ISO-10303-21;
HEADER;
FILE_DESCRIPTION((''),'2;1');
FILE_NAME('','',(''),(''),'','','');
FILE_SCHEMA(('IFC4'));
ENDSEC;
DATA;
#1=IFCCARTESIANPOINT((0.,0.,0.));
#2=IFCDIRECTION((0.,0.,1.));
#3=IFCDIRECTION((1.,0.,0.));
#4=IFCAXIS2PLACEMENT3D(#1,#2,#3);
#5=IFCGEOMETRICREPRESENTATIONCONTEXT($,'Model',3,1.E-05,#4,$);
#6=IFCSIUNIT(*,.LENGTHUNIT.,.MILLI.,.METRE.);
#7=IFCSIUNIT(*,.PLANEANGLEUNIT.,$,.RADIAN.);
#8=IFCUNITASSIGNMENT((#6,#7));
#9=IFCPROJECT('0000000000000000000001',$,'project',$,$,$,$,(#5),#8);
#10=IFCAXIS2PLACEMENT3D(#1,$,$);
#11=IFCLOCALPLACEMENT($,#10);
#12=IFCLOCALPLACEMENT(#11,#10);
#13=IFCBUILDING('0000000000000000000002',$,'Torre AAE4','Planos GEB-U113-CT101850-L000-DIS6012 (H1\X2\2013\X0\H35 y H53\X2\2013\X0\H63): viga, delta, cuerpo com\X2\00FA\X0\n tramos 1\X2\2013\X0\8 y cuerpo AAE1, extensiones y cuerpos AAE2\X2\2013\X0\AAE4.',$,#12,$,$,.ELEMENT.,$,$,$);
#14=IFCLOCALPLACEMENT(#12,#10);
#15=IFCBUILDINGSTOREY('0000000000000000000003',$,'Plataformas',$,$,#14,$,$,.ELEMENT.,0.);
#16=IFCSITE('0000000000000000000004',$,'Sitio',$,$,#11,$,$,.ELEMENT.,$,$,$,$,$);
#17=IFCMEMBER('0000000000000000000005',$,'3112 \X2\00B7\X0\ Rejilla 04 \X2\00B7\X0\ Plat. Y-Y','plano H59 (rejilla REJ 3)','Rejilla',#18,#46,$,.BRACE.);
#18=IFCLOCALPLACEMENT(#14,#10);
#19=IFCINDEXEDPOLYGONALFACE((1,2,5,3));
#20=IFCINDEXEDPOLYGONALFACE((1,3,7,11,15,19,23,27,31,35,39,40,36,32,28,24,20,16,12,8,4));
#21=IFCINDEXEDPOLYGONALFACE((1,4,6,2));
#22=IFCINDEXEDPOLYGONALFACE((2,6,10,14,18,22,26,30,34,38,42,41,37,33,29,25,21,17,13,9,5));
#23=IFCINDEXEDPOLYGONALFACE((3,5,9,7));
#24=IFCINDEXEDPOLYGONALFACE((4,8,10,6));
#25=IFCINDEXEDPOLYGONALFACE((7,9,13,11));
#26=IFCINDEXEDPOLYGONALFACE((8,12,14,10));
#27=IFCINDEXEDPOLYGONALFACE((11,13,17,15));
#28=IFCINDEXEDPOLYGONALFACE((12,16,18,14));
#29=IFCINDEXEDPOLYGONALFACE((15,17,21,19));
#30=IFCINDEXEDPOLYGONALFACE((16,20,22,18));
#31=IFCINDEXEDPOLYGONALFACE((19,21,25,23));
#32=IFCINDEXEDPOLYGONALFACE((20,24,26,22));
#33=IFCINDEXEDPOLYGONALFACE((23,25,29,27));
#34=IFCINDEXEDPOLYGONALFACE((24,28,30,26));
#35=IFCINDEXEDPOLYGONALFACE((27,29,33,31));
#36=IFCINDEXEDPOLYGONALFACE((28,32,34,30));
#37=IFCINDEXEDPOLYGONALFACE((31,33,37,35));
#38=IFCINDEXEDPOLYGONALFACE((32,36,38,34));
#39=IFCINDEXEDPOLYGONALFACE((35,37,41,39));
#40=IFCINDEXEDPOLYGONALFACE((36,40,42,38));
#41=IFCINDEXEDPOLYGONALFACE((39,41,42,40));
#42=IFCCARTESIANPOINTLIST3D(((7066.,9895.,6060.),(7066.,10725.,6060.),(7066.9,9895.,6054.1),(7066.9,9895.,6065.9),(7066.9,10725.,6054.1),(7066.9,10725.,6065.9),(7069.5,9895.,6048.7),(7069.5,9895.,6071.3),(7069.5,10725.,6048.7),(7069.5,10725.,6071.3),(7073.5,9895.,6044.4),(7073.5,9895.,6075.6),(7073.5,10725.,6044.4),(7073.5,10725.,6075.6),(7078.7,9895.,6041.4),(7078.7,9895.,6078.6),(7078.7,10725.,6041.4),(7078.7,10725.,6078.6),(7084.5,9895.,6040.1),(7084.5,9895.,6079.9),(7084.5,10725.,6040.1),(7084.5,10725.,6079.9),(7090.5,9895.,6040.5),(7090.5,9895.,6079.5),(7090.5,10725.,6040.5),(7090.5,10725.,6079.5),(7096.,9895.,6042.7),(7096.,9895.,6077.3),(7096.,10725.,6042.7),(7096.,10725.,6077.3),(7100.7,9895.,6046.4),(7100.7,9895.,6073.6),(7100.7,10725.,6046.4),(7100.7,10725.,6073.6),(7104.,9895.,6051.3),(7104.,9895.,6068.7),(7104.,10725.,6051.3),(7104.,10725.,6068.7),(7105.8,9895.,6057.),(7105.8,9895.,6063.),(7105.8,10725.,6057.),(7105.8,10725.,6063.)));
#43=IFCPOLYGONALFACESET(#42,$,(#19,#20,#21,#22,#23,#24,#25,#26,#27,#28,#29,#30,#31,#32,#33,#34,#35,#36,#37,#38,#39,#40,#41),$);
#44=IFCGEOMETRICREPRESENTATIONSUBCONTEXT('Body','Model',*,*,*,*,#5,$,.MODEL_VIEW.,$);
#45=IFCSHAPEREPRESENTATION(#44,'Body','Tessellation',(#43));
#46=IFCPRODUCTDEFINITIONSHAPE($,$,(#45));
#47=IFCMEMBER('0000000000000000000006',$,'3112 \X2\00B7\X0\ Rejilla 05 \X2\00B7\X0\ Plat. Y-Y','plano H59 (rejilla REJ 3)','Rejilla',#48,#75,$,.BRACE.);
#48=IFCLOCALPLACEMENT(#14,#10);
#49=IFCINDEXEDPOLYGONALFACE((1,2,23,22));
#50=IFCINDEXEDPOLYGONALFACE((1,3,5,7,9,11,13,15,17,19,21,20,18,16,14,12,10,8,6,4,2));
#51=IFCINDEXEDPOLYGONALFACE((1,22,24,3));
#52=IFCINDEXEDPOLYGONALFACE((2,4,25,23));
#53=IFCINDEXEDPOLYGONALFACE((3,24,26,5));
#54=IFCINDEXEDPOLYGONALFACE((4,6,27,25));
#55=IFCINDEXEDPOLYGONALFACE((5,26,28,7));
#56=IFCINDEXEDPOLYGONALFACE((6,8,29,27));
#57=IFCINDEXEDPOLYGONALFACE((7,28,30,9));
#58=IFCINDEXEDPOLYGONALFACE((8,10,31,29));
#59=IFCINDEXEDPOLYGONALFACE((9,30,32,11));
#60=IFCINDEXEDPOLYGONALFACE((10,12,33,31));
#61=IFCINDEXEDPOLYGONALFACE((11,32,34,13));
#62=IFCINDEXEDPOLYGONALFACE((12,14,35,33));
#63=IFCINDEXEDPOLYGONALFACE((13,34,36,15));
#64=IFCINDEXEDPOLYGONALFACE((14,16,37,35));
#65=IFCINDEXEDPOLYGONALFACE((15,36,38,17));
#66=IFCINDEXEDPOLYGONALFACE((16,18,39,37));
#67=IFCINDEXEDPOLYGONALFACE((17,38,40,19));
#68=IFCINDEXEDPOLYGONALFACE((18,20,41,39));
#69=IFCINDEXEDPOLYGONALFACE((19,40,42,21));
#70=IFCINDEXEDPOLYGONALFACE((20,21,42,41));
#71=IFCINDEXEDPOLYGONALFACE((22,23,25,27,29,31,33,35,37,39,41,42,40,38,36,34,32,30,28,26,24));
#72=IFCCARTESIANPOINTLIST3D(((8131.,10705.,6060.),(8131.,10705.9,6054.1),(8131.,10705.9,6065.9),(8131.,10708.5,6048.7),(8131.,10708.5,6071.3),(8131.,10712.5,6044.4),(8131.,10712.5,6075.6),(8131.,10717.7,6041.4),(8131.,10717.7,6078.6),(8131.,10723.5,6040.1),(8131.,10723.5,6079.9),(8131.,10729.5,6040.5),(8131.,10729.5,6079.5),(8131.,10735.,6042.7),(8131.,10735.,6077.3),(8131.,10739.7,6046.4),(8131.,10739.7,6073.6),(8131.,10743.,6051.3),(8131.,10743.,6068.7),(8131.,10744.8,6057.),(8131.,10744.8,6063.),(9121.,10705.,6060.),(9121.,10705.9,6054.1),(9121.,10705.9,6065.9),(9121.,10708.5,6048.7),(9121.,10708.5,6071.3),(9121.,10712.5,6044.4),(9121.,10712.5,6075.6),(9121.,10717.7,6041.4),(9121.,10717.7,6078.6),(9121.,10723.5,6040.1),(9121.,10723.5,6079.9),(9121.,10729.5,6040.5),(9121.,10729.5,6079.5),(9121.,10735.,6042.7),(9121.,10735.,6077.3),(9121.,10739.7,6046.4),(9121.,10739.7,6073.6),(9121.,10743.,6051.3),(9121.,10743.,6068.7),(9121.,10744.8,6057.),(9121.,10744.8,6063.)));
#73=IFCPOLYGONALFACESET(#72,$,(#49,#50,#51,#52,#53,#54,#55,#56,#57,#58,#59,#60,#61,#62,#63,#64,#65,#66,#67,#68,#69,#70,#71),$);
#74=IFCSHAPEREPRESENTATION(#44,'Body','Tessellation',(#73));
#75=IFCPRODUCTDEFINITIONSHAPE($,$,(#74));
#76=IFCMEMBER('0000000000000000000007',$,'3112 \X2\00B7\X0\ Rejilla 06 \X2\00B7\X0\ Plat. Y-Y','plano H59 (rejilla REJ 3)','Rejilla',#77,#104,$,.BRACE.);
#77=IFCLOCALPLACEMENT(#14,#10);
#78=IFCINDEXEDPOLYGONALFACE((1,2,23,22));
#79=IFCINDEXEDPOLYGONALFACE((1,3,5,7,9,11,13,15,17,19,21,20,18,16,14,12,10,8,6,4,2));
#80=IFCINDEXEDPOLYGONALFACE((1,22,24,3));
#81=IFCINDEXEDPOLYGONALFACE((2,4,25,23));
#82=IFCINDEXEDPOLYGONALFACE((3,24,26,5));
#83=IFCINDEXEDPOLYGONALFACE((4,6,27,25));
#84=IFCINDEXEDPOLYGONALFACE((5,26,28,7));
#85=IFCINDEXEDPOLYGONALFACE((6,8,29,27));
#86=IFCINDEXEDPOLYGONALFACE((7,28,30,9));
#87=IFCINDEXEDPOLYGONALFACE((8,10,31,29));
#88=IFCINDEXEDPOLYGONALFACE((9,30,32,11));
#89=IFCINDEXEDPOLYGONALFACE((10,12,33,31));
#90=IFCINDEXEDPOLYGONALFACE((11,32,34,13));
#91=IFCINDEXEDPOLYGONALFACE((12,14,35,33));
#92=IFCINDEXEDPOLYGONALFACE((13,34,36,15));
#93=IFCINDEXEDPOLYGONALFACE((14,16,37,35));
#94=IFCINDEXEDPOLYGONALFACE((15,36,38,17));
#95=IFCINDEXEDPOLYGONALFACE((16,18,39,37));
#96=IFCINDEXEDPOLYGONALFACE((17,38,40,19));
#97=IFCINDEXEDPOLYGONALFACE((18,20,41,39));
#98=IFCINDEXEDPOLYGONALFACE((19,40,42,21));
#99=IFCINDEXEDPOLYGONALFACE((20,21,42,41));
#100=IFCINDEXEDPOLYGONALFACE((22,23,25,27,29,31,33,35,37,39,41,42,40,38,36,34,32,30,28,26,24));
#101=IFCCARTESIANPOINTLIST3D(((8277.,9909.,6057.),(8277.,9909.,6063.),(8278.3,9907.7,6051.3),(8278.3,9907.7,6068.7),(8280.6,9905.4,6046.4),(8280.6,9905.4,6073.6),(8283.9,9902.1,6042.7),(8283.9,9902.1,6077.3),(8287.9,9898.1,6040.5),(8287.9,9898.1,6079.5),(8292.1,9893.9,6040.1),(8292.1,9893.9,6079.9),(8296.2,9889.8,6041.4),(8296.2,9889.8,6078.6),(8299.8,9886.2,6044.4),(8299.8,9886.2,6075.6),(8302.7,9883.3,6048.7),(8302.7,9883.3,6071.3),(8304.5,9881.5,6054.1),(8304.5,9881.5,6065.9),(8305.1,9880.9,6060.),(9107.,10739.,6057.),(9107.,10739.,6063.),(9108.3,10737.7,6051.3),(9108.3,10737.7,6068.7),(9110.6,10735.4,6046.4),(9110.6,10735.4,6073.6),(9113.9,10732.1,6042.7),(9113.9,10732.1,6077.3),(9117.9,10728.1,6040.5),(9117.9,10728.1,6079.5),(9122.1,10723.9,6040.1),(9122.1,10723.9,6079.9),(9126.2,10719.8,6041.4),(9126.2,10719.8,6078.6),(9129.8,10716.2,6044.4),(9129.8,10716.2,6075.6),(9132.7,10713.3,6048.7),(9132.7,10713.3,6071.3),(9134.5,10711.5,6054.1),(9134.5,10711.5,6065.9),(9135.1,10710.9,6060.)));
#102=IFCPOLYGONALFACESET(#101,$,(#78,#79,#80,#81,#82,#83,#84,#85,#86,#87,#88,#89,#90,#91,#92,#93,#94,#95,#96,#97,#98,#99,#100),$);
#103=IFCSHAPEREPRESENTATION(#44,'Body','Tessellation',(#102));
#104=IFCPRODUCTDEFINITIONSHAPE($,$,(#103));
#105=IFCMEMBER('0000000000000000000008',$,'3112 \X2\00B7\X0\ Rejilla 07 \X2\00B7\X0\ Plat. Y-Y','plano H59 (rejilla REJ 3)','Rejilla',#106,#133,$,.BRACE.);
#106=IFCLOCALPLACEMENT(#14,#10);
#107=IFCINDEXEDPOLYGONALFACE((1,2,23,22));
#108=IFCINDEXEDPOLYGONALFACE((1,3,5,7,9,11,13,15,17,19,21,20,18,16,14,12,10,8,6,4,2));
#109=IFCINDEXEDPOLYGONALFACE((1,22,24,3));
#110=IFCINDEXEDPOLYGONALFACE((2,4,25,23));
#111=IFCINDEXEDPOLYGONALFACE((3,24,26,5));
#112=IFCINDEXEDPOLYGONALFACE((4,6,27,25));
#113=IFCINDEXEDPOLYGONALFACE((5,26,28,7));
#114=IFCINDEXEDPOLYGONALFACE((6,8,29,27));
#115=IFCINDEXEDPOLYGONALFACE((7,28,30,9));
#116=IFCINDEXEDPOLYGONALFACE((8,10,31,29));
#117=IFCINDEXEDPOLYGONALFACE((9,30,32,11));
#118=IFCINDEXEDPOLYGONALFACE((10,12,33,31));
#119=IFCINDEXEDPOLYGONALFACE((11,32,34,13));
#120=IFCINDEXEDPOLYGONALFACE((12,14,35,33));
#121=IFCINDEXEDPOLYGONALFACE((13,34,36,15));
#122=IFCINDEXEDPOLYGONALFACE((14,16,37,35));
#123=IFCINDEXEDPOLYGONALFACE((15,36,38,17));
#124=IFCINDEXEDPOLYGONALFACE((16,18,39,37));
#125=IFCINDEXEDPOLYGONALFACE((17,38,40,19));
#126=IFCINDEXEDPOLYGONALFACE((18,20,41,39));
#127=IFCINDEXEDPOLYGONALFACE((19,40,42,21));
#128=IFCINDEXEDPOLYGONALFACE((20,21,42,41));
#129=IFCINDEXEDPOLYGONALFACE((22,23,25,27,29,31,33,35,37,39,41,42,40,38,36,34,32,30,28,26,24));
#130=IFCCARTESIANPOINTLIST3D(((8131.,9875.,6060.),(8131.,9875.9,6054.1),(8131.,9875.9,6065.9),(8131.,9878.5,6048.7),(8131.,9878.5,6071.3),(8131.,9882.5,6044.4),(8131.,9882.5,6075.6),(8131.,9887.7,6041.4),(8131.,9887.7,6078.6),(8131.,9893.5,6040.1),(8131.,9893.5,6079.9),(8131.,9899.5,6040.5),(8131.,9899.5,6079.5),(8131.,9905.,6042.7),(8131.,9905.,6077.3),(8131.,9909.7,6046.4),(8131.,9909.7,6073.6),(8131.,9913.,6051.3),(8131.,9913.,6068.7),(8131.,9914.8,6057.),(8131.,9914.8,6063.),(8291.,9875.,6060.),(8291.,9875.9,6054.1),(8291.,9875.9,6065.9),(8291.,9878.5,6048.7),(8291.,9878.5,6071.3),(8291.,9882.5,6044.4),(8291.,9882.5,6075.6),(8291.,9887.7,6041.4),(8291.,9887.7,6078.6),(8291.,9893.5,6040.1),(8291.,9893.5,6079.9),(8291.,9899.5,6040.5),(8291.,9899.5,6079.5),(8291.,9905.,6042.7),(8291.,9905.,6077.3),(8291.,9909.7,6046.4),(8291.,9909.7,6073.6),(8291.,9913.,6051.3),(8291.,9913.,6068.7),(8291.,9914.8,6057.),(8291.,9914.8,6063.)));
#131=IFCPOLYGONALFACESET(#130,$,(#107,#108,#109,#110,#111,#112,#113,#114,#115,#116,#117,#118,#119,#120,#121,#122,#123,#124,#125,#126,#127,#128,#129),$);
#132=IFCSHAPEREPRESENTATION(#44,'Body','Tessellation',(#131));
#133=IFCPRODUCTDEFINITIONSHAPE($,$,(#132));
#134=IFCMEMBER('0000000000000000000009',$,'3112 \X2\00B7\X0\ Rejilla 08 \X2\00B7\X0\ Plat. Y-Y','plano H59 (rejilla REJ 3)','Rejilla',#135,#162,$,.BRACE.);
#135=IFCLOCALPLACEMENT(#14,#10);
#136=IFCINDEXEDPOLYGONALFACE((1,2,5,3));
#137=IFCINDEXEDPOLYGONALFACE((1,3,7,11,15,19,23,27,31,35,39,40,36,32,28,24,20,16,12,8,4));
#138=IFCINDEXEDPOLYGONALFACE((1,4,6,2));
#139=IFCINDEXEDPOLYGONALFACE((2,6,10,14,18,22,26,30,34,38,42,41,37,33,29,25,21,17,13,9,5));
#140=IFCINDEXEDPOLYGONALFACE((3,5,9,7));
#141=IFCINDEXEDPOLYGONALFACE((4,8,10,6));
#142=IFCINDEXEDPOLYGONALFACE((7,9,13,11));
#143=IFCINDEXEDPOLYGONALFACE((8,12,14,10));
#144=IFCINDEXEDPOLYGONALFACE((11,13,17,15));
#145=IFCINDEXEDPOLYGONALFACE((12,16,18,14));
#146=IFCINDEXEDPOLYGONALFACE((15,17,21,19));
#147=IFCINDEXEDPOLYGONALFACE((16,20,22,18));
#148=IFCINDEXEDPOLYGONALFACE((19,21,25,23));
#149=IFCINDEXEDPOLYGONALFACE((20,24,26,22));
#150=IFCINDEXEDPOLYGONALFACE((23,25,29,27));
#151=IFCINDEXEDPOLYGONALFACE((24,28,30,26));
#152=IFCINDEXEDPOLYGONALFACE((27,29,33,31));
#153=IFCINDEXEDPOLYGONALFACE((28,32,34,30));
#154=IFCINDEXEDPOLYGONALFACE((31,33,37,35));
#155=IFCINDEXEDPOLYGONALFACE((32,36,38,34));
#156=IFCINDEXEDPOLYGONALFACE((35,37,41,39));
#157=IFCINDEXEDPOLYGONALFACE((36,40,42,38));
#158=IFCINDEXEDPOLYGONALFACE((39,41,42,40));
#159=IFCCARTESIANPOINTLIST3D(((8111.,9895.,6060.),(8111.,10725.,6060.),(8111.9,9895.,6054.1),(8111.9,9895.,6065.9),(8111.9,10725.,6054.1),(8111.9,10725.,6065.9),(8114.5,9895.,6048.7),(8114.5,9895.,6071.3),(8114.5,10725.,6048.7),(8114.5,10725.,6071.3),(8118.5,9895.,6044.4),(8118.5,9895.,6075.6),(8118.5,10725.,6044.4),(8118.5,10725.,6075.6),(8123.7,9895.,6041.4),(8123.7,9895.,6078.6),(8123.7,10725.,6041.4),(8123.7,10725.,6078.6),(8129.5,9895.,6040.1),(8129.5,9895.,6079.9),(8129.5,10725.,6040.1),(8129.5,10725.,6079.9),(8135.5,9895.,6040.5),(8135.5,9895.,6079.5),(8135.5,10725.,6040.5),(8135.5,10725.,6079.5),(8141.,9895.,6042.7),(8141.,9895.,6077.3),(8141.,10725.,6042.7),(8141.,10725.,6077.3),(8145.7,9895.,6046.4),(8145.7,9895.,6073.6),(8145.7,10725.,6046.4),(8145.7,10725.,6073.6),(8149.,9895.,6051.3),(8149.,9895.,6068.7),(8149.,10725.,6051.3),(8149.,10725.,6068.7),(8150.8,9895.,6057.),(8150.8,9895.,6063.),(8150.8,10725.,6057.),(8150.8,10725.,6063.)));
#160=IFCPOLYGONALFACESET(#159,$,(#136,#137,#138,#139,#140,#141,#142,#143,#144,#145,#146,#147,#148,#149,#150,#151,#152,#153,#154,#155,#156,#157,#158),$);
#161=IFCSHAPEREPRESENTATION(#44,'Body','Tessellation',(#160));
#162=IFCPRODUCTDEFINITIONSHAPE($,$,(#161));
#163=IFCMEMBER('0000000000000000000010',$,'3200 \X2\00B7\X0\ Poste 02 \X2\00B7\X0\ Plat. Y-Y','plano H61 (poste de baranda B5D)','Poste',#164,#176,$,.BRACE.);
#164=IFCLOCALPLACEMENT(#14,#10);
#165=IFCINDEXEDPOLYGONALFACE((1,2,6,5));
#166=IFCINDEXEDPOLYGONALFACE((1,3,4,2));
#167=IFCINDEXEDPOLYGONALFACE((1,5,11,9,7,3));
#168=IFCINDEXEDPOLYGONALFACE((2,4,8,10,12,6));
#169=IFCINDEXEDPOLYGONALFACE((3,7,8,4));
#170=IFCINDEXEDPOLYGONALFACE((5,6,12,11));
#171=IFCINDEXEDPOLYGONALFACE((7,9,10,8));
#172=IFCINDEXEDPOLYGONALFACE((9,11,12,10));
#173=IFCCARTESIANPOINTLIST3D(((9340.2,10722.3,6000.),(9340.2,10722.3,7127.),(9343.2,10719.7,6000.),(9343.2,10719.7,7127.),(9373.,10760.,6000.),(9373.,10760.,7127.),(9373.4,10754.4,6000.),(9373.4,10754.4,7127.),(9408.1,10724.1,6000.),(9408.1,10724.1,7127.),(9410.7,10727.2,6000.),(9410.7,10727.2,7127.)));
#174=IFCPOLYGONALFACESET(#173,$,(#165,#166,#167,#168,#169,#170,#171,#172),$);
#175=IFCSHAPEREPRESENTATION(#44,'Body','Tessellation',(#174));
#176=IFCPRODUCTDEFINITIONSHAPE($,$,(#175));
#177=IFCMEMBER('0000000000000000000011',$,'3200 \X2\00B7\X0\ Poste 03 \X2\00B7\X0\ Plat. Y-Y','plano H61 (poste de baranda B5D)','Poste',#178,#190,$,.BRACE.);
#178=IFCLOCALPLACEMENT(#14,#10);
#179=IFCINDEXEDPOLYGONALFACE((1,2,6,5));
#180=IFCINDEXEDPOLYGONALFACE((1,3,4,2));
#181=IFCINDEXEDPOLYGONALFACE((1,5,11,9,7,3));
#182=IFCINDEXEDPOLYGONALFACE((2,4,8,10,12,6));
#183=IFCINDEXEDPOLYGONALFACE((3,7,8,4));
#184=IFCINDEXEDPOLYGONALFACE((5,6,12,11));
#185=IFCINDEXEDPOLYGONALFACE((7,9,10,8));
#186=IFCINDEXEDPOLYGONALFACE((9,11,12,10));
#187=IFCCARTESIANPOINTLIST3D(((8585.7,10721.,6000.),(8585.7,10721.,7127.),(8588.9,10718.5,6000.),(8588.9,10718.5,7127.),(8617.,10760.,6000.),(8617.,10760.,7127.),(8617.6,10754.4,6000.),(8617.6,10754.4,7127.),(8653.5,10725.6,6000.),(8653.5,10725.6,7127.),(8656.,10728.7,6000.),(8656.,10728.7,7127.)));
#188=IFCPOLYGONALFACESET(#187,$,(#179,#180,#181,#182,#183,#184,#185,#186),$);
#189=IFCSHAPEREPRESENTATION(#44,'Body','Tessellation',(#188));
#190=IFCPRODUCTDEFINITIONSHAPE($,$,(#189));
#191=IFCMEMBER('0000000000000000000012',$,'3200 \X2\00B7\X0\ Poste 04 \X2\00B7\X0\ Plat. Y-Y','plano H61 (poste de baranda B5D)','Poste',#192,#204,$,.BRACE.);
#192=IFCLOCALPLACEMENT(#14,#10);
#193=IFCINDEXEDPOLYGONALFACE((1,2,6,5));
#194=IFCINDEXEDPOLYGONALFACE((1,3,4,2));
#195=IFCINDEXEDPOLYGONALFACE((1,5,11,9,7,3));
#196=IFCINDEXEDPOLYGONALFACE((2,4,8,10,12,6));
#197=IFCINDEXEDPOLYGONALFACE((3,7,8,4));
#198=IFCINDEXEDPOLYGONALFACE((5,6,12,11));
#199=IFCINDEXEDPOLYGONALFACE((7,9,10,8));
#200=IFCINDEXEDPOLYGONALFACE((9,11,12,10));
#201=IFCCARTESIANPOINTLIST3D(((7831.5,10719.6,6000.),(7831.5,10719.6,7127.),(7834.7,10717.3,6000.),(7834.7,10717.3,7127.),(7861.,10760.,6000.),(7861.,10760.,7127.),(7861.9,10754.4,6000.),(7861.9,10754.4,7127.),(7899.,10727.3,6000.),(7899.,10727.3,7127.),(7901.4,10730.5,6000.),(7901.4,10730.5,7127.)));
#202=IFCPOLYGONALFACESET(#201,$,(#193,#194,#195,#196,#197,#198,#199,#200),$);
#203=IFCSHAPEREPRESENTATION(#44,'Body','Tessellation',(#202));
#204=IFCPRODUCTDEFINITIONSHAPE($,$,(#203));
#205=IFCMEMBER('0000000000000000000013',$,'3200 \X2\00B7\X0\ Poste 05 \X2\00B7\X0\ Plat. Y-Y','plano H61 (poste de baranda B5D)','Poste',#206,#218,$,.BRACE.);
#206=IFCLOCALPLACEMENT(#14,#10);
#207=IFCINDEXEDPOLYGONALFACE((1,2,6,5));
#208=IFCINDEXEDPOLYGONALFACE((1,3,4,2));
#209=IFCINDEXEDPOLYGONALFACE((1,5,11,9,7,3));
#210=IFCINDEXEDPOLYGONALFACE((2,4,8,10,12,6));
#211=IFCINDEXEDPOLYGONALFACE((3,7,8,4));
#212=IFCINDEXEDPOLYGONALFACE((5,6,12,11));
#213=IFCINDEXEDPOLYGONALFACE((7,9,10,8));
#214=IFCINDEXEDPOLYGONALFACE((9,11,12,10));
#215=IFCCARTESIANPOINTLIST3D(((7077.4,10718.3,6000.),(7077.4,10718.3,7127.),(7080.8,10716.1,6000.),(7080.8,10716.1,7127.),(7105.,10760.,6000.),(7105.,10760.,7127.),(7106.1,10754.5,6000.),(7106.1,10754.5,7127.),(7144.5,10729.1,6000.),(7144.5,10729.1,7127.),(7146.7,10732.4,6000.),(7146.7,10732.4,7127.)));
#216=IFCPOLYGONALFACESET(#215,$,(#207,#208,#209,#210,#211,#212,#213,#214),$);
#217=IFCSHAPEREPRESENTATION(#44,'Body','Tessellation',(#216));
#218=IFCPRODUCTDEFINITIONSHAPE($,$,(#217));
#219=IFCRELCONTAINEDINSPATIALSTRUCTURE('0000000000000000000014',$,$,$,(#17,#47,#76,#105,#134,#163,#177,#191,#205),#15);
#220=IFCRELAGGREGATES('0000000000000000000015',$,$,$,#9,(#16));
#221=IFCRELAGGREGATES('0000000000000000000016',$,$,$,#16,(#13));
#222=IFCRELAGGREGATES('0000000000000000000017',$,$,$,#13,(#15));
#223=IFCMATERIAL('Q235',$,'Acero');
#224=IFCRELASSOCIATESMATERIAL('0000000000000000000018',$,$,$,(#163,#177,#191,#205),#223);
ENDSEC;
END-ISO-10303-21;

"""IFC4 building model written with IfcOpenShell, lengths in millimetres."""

from ifc_helpers import new_model, si_unit, frame, frame_2d, origin, origin_with_axes, place, context, subcontext, project, spatial, circle, l_section, extrude, material, element, save


model = new_model("IFC4")

# Units and contexts
model_context = context("Model", 3, precision=1e-05, world=origin_with_axes())
body_context = subcontext(model_context, "Body", "Model", "MODEL_VIEW")
ifc_project = project(units=[si_unit("LENGTHUNIT", "METRE", prefix="MILLI"), si_unit("PLANEANGLEUNIT", "RADIAN")], contexts=[model_context])

# Site, building, storey
site_placement = place(None, origin())
site = spatial("IfcSite", under=ifc_project, at=site_placement, Name="Sitio", CompositionType="ELEMENT")
building_placement = place(site_placement, origin())
building = spatial("IfcBuilding", under=site, at=building_placement, Name="Torre AAE4", Description="Planos GEB-U113-CT101850-L000-DIS6012 (H1–H35 y H53–H63): viga, delta, cuerpo común tramos 1–8 y cuerpo AAE1, extensiones y cuerpos AAE2–AAE4.", CompositionType="ELEMENT")
storey_placement = place(building_placement, origin())
storey = spatial("IfcBuildingStorey", under=building, at=storey_placement, Name="Plataformas", CompositionType="ELEMENT", Elevation=0.0)

# Members
member_1_placement = place(storey_placement, frame((7086.0, 9895.0, 6060.0), z_axis=(0.0, 1.0, 0.0), x_axis=(-1.0, 0.0, 0.0)))
element("IfcMember", 1, at=member_1_placement, inside=storey, Name="3112 · Rejilla 04 · Plat. Y-Y", Description="plano H59 (rejilla REJ 3)", ObjectType="Rejilla", PredefinedType="BRACE", context=body_context, shape_type="SweptSolid", body=[
    extrude(circle(Radius=20.0), None, (0.0, 0.0, 1.0), 830.0),
])
member_2_placement = place(storey_placement, frame((8131.0, 10725.0, 6060.0), z_axis=(1.0, 0.0, 0.0), x_axis=(0.0, -1.0, 0.0)))
element("IfcMember", 2, at=member_2_placement, inside=storey, Name="3112 · Rejilla 05 · Plat. Y-Y", Description="plano H59 (rejilla REJ 3)", ObjectType="Rejilla", PredefinedType="BRACE", context=body_context, shape_type="SweptSolid", body=[
    extrude(circle(Radius=20.0), None, (0.0, 0.0, 1.0), 990.0),
])
member_3_placement = place(storey_placement, frame((9121.0, 10725.0, 6060.0), z_axis=(-0.707107, -0.707107, 0.0), x_axis=(0.707107, -0.707107, 0.0)))
element("IfcMember", 3, at=member_3_placement, inside=storey, Name="3112 · Rejilla 06 · Plat. Y-Y", Description="plano H59 (rejilla REJ 3)", ObjectType="Rejilla", PredefinedType="BRACE", context=body_context, shape_type="SweptSolid", body=[
    extrude(circle(Radius=20.0), None, (0.0, 0.0, 1.0), 1173.8),
])
member_4_placement = place(storey_placement, frame((8291.0, 9895.0, 6060.0), z_axis=(-1.0, 0.0, 0.0), x_axis=(0.0, -1.0, 0.0)))
element("IfcMember", 4, at=member_4_placement, inside=storey, Name="3112 · Rejilla 07 · Plat. Y-Y", Description="plano H59 (rejilla REJ 3)", ObjectType="Rejilla", PredefinedType="BRACE", context=body_context, shape_type="SweptSolid", body=[
    extrude(circle(Radius=20.0), None, (0.0, 0.0, 1.0), 160.0),
])
member_5_placement = place(storey_placement, frame((8131.0, 9895.0, 6060.0), z_axis=(0.0, 1.0, 0.0), x_axis=(-1.0, 0.0, 0.0)))
element("IfcMember", 5, at=member_5_placement, inside=storey, Name="3112 · Rejilla 08 · Plat. Y-Y", Description="plano H59 (rejilla REJ 3)", ObjectType="Rejilla", PredefinedType="BRACE", context=body_context, shape_type="SweptSolid", body=[
    extrude(circle(Radius=20.0), None, (0.0, 0.0, 1.0), 830.0),
])
ifc_material = material(Name="Q235", Category="Acero")
for number, where, z_axis, x_axis, name in (
    (6, (9373.0, 10760.0, 6000.0), (0.0, 0.0, 1.0), (-0.656836, -0.754033, 0.0), "3200 · Poste 02 · Plat. Y-Y"),
    (7, (8617.0, 10760.0, 6000.0), (0.0, 0.0, 1.0), (-0.625093, -0.78055, 0.0), "3200 · Poste 03 · Plat. Y-Y"),
    (8, (7861.0, 10760.0, 6000.0), (0.0, 0.0, 1.0), (-0.589915, -0.807465, 0.0), "3200 · Poste 04 · Plat. Y-Y"),
    (9, (7105.0, 10760.0, 6000.0), (0.0, 0.0, 1.0), (-0.551026, -0.834488, 0.0), "3200 · Poste 05 · Plat. Y-Y"),
):
    element("IfcMember", number, at=place(storey_placement, frame(where, z_axis=z_axis, x_axis=x_axis)), inside=storey, material=ifc_material, Name=name, Description="plano H61 (poste de baranda B5D)", ObjectType="Poste", PredefinedType="BRACE", context=body_context, shape_type="SweptSolid", body=[
        extrude(l_section(Depth=50.0, Width=50.0, Thickness=4.0, at=frame_2d((25.0, 25.0))), None, (0.0, 0.0, 1.0), 1127.0),
    ])

save(model, "model.ifc")
